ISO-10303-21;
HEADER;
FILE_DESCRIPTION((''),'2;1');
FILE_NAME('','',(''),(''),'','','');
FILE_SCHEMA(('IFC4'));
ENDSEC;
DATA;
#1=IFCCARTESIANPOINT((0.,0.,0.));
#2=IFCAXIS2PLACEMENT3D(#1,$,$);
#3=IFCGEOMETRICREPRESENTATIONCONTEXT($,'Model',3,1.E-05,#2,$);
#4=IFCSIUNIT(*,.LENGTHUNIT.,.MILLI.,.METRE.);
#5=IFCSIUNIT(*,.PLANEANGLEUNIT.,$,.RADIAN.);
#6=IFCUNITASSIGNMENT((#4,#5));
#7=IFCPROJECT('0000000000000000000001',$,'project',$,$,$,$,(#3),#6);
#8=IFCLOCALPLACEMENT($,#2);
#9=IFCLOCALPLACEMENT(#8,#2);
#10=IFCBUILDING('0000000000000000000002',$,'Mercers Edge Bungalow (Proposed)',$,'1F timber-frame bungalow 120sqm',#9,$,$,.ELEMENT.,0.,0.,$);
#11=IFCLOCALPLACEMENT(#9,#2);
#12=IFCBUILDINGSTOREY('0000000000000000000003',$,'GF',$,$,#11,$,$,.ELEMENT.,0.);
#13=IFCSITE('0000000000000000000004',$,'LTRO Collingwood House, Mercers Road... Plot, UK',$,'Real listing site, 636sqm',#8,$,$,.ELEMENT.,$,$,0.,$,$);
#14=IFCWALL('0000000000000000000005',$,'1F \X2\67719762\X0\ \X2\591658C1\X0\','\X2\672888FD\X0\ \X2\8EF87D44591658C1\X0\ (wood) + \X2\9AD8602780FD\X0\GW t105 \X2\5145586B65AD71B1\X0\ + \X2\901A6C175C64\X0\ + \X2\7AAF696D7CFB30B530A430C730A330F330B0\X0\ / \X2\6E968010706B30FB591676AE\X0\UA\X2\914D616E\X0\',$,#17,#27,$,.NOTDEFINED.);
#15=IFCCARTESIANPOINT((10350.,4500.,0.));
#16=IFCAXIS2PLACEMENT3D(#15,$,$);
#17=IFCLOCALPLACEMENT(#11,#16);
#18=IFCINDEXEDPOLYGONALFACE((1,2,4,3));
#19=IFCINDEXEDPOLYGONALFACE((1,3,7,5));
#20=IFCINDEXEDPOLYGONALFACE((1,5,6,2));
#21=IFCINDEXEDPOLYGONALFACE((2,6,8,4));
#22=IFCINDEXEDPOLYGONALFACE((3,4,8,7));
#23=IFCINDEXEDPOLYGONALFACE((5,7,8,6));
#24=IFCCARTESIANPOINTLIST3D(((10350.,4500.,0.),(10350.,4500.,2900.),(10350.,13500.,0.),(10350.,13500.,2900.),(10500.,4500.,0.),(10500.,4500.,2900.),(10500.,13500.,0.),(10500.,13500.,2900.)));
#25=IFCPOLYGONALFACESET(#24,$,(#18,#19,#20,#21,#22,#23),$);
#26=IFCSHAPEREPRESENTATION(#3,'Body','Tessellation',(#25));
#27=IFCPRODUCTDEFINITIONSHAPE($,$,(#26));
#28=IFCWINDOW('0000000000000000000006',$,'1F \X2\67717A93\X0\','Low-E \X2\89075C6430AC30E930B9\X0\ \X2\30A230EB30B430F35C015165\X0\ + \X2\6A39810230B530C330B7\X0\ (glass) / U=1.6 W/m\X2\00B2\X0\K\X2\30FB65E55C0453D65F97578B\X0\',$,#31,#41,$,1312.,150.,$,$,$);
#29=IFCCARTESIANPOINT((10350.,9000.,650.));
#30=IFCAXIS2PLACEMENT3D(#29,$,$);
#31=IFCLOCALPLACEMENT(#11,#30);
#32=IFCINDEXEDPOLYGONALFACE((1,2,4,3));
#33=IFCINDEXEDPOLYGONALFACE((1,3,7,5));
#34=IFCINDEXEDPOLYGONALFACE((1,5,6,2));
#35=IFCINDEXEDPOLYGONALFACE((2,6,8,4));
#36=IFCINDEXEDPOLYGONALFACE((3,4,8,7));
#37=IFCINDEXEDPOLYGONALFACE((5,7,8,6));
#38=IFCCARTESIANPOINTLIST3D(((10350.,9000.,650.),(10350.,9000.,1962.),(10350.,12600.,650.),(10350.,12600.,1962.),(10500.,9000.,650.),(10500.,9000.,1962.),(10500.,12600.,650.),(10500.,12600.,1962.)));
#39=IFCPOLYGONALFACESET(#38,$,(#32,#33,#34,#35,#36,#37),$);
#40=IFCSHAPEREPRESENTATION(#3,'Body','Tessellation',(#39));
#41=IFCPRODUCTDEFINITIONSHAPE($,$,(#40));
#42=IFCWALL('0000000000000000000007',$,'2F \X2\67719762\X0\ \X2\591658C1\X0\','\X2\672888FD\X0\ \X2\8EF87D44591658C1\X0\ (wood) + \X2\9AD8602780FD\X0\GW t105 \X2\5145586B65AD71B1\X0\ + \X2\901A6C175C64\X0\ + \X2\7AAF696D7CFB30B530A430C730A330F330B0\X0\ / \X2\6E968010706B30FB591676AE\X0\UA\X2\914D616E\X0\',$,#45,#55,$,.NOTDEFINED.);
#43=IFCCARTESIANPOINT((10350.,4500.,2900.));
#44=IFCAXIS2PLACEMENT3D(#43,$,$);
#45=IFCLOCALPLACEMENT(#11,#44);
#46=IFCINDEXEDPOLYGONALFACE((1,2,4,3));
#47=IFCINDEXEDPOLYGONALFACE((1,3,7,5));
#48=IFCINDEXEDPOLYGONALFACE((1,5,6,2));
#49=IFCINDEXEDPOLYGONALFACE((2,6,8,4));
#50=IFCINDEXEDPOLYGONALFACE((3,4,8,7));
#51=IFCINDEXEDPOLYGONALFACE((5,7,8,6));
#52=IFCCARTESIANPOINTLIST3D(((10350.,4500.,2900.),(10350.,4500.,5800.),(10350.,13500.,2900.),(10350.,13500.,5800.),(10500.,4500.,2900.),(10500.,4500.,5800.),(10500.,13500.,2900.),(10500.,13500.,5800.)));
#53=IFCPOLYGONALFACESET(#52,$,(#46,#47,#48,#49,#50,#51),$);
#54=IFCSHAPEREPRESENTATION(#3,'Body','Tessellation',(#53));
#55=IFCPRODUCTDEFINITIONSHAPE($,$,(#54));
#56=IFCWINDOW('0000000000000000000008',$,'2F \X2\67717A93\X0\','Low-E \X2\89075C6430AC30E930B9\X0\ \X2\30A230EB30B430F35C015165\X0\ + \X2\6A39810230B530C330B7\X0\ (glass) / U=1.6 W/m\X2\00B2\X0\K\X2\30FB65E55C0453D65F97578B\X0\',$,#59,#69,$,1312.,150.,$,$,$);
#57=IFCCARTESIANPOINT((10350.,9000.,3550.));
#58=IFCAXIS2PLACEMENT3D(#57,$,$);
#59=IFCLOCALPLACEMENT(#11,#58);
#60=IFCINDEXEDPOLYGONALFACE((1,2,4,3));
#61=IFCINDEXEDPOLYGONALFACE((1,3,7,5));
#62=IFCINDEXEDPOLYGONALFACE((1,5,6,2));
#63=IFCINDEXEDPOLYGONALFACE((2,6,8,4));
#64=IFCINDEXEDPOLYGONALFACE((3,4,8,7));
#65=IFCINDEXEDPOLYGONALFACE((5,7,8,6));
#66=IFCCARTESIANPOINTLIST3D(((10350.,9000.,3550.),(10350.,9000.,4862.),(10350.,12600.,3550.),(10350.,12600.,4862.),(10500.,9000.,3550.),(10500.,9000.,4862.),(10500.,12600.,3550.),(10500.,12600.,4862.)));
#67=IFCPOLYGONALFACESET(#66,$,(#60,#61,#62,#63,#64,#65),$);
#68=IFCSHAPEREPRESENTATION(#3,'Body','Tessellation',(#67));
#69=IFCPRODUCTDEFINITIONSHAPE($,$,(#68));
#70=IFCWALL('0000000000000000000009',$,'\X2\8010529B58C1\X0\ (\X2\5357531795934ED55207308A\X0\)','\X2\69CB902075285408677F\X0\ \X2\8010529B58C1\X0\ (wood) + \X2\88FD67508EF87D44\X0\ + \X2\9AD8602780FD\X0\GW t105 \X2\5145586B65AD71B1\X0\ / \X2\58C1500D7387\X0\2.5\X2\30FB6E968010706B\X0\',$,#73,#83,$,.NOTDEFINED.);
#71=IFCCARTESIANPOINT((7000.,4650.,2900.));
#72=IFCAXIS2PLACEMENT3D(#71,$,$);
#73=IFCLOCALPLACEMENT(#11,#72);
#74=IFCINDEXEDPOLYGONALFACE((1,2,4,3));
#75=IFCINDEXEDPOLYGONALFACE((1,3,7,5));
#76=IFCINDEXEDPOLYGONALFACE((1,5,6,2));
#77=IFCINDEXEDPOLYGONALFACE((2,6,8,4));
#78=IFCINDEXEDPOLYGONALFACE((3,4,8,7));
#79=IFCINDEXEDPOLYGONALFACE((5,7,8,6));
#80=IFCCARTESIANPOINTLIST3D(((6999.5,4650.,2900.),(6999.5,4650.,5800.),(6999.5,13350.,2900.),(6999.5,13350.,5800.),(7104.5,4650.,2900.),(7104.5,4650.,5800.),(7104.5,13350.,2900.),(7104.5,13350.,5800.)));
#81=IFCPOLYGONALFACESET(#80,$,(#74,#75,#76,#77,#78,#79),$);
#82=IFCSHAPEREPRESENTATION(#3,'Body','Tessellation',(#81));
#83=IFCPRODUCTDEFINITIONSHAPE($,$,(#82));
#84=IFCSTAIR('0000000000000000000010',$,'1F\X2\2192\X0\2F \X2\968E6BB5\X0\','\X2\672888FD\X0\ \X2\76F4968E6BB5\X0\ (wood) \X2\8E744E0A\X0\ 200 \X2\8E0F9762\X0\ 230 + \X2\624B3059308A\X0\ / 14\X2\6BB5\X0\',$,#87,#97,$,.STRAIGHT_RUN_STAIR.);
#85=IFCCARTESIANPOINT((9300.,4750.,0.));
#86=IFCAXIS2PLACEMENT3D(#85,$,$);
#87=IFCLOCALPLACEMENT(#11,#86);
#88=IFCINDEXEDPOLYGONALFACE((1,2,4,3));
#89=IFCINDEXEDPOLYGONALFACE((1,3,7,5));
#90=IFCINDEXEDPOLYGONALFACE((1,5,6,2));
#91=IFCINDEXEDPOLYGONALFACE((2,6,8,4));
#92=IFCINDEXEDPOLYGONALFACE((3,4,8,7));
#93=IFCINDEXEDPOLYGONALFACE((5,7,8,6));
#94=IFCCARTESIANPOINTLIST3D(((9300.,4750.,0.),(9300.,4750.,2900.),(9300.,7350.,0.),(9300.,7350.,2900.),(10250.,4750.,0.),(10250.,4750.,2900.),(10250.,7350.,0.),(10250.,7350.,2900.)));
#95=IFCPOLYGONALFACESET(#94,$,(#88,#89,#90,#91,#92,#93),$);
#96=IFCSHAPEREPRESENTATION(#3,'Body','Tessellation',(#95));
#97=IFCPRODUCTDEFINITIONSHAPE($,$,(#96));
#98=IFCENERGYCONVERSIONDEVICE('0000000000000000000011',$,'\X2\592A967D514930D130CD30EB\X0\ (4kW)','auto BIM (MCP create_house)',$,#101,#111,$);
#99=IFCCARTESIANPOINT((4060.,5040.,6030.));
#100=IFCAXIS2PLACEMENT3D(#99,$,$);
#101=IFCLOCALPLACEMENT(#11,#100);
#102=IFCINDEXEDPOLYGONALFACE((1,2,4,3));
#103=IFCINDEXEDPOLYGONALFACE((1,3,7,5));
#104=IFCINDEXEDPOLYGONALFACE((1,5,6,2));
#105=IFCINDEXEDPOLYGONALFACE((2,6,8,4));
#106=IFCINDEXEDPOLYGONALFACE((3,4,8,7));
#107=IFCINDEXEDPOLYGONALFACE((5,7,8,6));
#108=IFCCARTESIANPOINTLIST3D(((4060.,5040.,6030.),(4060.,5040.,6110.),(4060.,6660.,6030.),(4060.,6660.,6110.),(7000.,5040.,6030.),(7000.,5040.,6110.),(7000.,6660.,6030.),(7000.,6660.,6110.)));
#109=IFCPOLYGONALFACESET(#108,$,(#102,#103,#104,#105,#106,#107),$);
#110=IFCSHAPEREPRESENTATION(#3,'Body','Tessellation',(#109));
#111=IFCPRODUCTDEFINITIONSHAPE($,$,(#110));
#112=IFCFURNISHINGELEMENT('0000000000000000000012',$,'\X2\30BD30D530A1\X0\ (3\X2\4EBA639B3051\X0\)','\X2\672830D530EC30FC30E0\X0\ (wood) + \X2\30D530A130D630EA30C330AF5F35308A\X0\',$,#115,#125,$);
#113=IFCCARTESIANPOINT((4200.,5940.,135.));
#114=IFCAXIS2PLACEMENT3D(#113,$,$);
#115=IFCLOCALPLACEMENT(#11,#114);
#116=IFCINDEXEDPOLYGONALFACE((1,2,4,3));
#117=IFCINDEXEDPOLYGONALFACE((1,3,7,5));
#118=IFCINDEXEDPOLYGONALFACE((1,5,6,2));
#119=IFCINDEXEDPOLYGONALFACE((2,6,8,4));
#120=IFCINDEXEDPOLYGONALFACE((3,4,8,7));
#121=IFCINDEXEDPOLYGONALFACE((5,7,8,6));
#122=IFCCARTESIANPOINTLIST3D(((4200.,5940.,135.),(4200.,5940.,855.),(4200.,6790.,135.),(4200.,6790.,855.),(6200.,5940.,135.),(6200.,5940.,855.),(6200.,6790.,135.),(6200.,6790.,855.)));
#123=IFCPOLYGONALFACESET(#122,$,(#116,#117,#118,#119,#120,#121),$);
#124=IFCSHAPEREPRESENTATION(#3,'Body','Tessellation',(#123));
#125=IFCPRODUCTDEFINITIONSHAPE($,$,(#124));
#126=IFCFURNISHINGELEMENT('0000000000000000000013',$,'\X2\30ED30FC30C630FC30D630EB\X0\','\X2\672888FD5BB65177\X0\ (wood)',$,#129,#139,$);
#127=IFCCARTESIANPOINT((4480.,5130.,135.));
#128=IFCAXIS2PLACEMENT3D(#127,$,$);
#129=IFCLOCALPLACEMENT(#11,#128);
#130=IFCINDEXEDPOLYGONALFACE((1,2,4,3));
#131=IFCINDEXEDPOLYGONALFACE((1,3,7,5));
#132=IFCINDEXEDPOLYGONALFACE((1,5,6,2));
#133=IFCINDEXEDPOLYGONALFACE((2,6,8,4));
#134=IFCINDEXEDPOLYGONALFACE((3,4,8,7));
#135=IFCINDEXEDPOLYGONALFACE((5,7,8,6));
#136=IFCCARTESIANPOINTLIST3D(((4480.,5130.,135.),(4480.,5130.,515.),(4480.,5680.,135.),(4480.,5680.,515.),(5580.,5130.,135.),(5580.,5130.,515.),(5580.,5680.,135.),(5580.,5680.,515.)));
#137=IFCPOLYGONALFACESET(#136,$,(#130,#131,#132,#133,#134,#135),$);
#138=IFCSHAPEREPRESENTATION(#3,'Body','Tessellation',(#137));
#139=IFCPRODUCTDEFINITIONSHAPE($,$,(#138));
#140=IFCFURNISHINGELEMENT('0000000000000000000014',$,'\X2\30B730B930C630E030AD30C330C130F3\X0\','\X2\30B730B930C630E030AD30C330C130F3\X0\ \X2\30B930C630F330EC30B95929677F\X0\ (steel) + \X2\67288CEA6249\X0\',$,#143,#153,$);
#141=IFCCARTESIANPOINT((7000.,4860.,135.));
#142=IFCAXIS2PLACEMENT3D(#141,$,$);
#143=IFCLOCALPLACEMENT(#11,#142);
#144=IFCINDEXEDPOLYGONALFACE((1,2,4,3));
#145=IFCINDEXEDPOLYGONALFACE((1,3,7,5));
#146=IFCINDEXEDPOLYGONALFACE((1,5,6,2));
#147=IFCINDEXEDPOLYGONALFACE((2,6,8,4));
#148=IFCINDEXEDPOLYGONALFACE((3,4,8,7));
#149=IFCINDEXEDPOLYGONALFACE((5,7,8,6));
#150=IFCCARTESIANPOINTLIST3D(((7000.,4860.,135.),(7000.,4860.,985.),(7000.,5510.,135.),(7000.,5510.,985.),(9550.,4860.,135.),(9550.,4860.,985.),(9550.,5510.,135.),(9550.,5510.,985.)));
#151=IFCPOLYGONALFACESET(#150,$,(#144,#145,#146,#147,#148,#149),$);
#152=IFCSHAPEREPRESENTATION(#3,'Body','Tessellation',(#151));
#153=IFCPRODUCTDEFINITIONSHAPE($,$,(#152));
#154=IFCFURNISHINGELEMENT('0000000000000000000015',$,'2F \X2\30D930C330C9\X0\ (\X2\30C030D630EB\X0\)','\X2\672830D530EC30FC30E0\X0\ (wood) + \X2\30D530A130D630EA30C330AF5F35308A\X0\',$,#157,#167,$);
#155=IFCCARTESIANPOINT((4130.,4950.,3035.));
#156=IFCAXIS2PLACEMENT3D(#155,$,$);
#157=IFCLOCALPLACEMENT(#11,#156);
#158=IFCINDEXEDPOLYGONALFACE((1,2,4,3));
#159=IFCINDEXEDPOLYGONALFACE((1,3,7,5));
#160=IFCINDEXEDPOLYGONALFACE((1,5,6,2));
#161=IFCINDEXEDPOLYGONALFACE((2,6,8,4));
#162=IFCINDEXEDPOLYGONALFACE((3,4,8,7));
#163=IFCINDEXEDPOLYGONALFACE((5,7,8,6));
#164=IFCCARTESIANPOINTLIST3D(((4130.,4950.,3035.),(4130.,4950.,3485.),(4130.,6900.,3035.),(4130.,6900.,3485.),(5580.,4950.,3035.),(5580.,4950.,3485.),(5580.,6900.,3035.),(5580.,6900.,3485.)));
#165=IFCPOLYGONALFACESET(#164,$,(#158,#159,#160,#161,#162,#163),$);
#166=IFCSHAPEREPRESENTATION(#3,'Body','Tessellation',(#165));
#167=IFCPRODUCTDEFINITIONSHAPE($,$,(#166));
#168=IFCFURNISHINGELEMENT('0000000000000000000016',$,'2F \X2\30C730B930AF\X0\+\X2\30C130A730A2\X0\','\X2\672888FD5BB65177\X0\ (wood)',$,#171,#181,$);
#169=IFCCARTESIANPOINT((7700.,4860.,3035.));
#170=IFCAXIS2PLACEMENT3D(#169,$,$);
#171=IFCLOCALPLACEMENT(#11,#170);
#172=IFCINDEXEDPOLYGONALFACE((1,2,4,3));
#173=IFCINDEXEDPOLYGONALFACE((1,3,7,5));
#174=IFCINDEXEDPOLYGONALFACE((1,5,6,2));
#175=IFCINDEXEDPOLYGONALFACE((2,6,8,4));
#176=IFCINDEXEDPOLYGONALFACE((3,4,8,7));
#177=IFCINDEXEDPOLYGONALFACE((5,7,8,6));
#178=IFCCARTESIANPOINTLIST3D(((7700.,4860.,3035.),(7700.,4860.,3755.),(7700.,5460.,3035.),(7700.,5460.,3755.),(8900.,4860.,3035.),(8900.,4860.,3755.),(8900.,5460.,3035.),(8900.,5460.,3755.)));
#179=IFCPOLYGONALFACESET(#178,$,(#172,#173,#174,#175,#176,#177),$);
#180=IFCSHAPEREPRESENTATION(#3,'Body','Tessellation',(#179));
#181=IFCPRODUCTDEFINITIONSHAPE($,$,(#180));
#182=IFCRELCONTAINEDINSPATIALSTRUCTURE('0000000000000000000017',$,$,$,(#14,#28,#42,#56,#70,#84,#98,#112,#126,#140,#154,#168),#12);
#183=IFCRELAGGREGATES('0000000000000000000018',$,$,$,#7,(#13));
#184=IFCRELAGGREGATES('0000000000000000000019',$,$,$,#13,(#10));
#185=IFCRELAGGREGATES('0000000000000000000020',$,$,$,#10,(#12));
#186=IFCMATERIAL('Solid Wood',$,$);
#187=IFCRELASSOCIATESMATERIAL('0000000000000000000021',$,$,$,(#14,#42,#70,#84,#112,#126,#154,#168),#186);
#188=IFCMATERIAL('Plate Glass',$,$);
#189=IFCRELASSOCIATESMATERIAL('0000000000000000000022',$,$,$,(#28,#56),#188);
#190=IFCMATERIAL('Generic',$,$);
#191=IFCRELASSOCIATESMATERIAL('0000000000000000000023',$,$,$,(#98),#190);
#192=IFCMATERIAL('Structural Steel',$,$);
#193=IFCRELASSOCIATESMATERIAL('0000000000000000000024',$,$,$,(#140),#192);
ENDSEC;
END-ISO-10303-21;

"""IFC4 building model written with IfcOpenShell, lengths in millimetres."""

from ifc_helpers import new_model, si_unit, frame, frame_2d, origin, place, context, project, spatial, rectangle, extrude, material, element, fill, save


model = new_model("IFC4")

# Units and contexts
model_context = context("Model", 3, precision=1e-05, world=origin())
ifc_project = project(units=[si_unit("LENGTHUNIT", "METRE", prefix="MILLI"), si_unit("PLANEANGLEUNIT", "RADIAN")], contexts=[model_context])

# Site, building, storey
site_placement = place(None, origin())
site = spatial("IfcSite", under=ifc_project, at=site_placement, Name="LTRO Collingwood House, Mercers Road... Plot, UK", ObjectType="Real listing site, 636sqm", CompositionType="ELEMENT", RefElevation=0.0)
building_placement = place(site_placement, origin())
building = spatial("IfcBuilding", under=site, at=building_placement, Name="Mercers Edge Bungalow (Proposed)", ObjectType="1F timber-frame bungalow 120sqm", CompositionType="ELEMENT", ElevationOfRefHeight=0.0, ElevationOfTerrain=0.0)
storey_placement = place(building_placement, origin())
storey = spatial("IfcBuildingStorey", under=building, at=storey_placement, Name="GF", CompositionType="ELEMENT", Elevation=0.0)

# Wall, opening, window
ifc_material_1 = material(Name="Solid Wood")
wall_1_placement = place(storey_placement, frame((10350.0, 4500.0, 0.0)))
wall_1 = element("IfcWall", 1, at=wall_1_placement, inside=storey, material=ifc_material_1, Name="1F 東面 外壁", Description="木製 軸組外壁 (wood) + 高性能GW t105 充填断熱 + 通気層 + 窯業系サイディング / 準耐火・外皮UA配慮", PredefinedType="NOTDEFINED", context=model_context, shape_type="SweptSolid", body=[
    extrude(rectangle(XDim=150.0, YDim=9000.0, at=frame_2d((75.0, 4500.0))), frame((10350.0, 4500.0, 0.0)), (0.0, 0.0, 1.0), 2900.0),
])
opening_1_placement = place(storey_placement, frame((10350.0, 9000.0, 650.0)))
opening_1 = element("IfcOpeningElement", 2, at=opening_1_placement, cuts=wall_1, PredefinedType="NOTDEFINED", context=model_context, shape_type="SweptSolid", body=[
    extrude(rectangle(XDim=150.0, YDim=3600.0, at=frame_2d((75.0, 1800.0))), frame((10350.0, 9000.0, 650.0)), (0.0, 0.0, 1.0), 1312.0),
])
ifc_material_2 = material(Name="Plate Glass")
window_1_placement = place(storey_placement, frame((10350.0, 9000.0, 650.0)))
window_1 = element("IfcWindow", 3, at=window_1_placement, inside=storey, material=ifc_material_2, Name="1F 東窓", Description="Low-E 複層ガラス アルゴン封入 + 樹脂サッシ (glass) / U=1.6 W/m²K・日射取得型", OverallHeight=1312.0, OverallWidth=150.0, context=model_context, shape_type="SweptSolid", body=[
    extrude(rectangle(XDim=150.0, YDim=3600.0, at=frame_2d((75.0, 1800.0))), frame((10350.0, 9000.0, 650.0)), (0.0, 0.0, 1.0), 1312.0),
])
fill(opening_1, window_1)

# Wall, opening, window
wall_2_placement = place(storey_placement, frame((10350.0, 4500.0, 2900.0)))
wall_2 = element("IfcWall", 4, at=wall_2_placement, inside=storey, material=ifc_material_1, Name="2F 東面 外壁", Description="木製 軸組外壁 (wood) + 高性能GW t105 充填断熱 + 通気層 + 窯業系サイディング / 準耐火・外皮UA配慮", PredefinedType="NOTDEFINED", context=model_context, shape_type="SweptSolid", body=[
    extrude(rectangle(XDim=150.0, YDim=9000.0, at=frame_2d((75.0, 4500.0))), frame((10350.0, 4500.0, 2900.0)), (0.0, 0.0, 1.0), 2900.0),
])
opening_2_placement = place(storey_placement, frame((10350.0, 9000.0, 3550.0)))
opening_2 = element("IfcOpeningElement", 5, at=opening_2_placement, cuts=wall_2, PredefinedType="NOTDEFINED", context=model_context, shape_type="SweptSolid", body=[
    extrude(rectangle(XDim=150.0, YDim=3600.0, at=frame_2d((75.0, 1800.0))), frame((10350.0, 9000.0, 3550.0)), (0.0, 0.0, 1.0), 1312.0),
])
window_2_placement = place(storey_placement, frame((10350.0, 9000.0, 3550.0)))
window_2 = element("IfcWindow", 6, at=window_2_placement, inside=storey, material=ifc_material_2, Name="2F 東窓", Description="Low-E 複層ガラス アルゴン封入 + 樹脂サッシ (glass) / U=1.6 W/m²K・日射取得型", OverallHeight=1312.0, OverallWidth=150.0, context=model_context, shape_type="SweptSolid", body=[
    extrude(rectangle(XDim=150.0, YDim=3600.0, at=frame_2d((75.0, 1800.0))), frame((10350.0, 9000.0, 3550.0)), (0.0, 0.0, 1.0), 1312.0),
])
fill(opening_2, window_2)

# Wall
wall_3_placement = place(storey_placement, frame((7000.0, 4650.0, 2900.0)))
element("IfcWall", 7, at=wall_3_placement, inside=storey, material=ifc_material_1, Name="耐力壁 (南北間仕切り)", Description="構造用合板 耐力壁 (wood) + 製材軸組 + 高性能GW t105 充填断熱 / 壁倍率2.5・準耐火", PredefinedType="NOTDEFINED", context=model_context, shape_type="SweptSolid", body=[
    extrude(rectangle(XDim=105.0, YDim=8700.0, at=frame_2d((52.0, 4350.0))), frame((7000.0, 4650.0, 2900.0)), (0.0, 0.0, 1.0), 2900.0),
])

# Stair
stair_placement = place(storey_placement, frame((9300.0, 4750.0, 0.0)))
element("IfcStair", 8, at=stair_placement, inside=storey, material=ifc_material_1, Name="1F→2F 階段", Description="木製 直階段 (wood) 蹴上 200 踏面 230 + 手すり / 14段", PredefinedType="STRAIGHT_RUN_STAIR", context=model_context, shape_type="SweptSolid", body=[
    extrude(rectangle(XDim=950.0, YDim=2600.0, at=frame_2d((475.0, 1300.0))), frame((9300.0, 4750.0, 0.0)), (0.0, 0.0, 1.0), 2900.0),
])

# Energy conversion device
ifc_material_3 = material(Name="Generic")
energy_conversion_device_placement = place(storey_placement, frame((4060.0, 5040.0, 6030.0)))
element("IfcEnergyConversionDevice", 9, at=energy_conversion_device_placement, inside=storey, material=ifc_material_3, Name="太陽光パネル (4kW)", Description="auto BIM (MCP create_house)", context=model_context, shape_type="SweptSolid", body=[
    extrude(rectangle(XDim=2940.0, YDim=1620.0, at=frame_2d((1470.0, 810.0))), frame((4060.0, 5040.0, 6030.0)), (0.0, 0.0, 1.0), 80.0),
])

# Furnishing elements
furnishing_1_placement = place(storey_placement, frame((4200.0, 5940.0, 135.0)))
element("IfcFurnishingElement", 10, at=furnishing_1_placement, inside=storey, material=ifc_material_1, Name="ソファ (3人掛け)", Description="木フレーム (wood) + ファブリック張り", context=model_context, shape_type="SweptSolid", body=[
    extrude(rectangle(XDim=2000.0, YDim=850.0, at=frame_2d((1000.0, 425.0))), frame((4200.0, 5940.0, 135.0)), (0.0, 0.0, 1.0), 720.0),
])
furnishing_2_placement = place(storey_placement, frame((4480.0, 5130.0, 135.0)))
element("IfcFurnishingElement", 11, at=furnishing_2_placement, inside=storey, material=ifc_material_1, Name="ローテーブル", Description="木製家具 (wood)", context=model_context, shape_type="SweptSolid", body=[
    extrude(rectangle(XDim=1100.0, YDim=550.0, at=frame_2d((550.0, 275.0))), frame((4480.0, 5130.0, 135.0)), (0.0, 0.0, 1.0), 380.0),
])
ifc_material_4 = material(Name="Structural Steel")
furnishing_3_placement = place(storey_placement, frame((7000.0, 4860.0, 135.0)))
element("IfcFurnishingElement", 12, at=furnishing_3_placement, inside=storey, material=ifc_material_4, Name="システムキッチン", Description="システムキッチン ステンレス天板 (steel) + 木質扉", context=model_context, shape_type="SweptSolid", body=[
    extrude(rectangle(XDim=2550.0, YDim=650.0, at=frame_2d((1275.0, 325.0))), frame((7000.0, 4860.0, 135.0)), (0.0, 0.0, 1.0), 850.0),
])
furnishing_4_placement = place(storey_placement, frame((4130.0, 4950.0, 3035.0)))
element("IfcFurnishingElement", 13, at=furnishing_4_placement, inside=storey, material=ifc_material_1, Name="2F ベッド (ダブル)", Description="木フレーム (wood) + ファブリック張り", context=model_context, shape_type="SweptSolid", body=[
    extrude(rectangle(XDim=1450.0, YDim=1950.0, at=frame_2d((725.0, 975.0))), frame((4130.0, 4950.0, 3035.0)), (0.0, 0.0, 1.0), 450.0),
])
furnishing_5_placement = place(storey_placement, frame((7700.0, 4860.0, 3035.0)))
element("IfcFurnishingElement", 14, at=furnishing_5_placement, inside=storey, material=ifc_material_1, Name="2F デスク+チェア", Description="木製家具 (wood)", context=model_context, shape_type="SweptSolid", body=[
    extrude(rectangle(XDim=1200.0, YDim=600.0, at=frame_2d((600.0, 300.0))), frame((7700.0, 4860.0, 3035.0)), (0.0, 0.0, 1.0), 720.0),
])

save(model, "model.ifc")
